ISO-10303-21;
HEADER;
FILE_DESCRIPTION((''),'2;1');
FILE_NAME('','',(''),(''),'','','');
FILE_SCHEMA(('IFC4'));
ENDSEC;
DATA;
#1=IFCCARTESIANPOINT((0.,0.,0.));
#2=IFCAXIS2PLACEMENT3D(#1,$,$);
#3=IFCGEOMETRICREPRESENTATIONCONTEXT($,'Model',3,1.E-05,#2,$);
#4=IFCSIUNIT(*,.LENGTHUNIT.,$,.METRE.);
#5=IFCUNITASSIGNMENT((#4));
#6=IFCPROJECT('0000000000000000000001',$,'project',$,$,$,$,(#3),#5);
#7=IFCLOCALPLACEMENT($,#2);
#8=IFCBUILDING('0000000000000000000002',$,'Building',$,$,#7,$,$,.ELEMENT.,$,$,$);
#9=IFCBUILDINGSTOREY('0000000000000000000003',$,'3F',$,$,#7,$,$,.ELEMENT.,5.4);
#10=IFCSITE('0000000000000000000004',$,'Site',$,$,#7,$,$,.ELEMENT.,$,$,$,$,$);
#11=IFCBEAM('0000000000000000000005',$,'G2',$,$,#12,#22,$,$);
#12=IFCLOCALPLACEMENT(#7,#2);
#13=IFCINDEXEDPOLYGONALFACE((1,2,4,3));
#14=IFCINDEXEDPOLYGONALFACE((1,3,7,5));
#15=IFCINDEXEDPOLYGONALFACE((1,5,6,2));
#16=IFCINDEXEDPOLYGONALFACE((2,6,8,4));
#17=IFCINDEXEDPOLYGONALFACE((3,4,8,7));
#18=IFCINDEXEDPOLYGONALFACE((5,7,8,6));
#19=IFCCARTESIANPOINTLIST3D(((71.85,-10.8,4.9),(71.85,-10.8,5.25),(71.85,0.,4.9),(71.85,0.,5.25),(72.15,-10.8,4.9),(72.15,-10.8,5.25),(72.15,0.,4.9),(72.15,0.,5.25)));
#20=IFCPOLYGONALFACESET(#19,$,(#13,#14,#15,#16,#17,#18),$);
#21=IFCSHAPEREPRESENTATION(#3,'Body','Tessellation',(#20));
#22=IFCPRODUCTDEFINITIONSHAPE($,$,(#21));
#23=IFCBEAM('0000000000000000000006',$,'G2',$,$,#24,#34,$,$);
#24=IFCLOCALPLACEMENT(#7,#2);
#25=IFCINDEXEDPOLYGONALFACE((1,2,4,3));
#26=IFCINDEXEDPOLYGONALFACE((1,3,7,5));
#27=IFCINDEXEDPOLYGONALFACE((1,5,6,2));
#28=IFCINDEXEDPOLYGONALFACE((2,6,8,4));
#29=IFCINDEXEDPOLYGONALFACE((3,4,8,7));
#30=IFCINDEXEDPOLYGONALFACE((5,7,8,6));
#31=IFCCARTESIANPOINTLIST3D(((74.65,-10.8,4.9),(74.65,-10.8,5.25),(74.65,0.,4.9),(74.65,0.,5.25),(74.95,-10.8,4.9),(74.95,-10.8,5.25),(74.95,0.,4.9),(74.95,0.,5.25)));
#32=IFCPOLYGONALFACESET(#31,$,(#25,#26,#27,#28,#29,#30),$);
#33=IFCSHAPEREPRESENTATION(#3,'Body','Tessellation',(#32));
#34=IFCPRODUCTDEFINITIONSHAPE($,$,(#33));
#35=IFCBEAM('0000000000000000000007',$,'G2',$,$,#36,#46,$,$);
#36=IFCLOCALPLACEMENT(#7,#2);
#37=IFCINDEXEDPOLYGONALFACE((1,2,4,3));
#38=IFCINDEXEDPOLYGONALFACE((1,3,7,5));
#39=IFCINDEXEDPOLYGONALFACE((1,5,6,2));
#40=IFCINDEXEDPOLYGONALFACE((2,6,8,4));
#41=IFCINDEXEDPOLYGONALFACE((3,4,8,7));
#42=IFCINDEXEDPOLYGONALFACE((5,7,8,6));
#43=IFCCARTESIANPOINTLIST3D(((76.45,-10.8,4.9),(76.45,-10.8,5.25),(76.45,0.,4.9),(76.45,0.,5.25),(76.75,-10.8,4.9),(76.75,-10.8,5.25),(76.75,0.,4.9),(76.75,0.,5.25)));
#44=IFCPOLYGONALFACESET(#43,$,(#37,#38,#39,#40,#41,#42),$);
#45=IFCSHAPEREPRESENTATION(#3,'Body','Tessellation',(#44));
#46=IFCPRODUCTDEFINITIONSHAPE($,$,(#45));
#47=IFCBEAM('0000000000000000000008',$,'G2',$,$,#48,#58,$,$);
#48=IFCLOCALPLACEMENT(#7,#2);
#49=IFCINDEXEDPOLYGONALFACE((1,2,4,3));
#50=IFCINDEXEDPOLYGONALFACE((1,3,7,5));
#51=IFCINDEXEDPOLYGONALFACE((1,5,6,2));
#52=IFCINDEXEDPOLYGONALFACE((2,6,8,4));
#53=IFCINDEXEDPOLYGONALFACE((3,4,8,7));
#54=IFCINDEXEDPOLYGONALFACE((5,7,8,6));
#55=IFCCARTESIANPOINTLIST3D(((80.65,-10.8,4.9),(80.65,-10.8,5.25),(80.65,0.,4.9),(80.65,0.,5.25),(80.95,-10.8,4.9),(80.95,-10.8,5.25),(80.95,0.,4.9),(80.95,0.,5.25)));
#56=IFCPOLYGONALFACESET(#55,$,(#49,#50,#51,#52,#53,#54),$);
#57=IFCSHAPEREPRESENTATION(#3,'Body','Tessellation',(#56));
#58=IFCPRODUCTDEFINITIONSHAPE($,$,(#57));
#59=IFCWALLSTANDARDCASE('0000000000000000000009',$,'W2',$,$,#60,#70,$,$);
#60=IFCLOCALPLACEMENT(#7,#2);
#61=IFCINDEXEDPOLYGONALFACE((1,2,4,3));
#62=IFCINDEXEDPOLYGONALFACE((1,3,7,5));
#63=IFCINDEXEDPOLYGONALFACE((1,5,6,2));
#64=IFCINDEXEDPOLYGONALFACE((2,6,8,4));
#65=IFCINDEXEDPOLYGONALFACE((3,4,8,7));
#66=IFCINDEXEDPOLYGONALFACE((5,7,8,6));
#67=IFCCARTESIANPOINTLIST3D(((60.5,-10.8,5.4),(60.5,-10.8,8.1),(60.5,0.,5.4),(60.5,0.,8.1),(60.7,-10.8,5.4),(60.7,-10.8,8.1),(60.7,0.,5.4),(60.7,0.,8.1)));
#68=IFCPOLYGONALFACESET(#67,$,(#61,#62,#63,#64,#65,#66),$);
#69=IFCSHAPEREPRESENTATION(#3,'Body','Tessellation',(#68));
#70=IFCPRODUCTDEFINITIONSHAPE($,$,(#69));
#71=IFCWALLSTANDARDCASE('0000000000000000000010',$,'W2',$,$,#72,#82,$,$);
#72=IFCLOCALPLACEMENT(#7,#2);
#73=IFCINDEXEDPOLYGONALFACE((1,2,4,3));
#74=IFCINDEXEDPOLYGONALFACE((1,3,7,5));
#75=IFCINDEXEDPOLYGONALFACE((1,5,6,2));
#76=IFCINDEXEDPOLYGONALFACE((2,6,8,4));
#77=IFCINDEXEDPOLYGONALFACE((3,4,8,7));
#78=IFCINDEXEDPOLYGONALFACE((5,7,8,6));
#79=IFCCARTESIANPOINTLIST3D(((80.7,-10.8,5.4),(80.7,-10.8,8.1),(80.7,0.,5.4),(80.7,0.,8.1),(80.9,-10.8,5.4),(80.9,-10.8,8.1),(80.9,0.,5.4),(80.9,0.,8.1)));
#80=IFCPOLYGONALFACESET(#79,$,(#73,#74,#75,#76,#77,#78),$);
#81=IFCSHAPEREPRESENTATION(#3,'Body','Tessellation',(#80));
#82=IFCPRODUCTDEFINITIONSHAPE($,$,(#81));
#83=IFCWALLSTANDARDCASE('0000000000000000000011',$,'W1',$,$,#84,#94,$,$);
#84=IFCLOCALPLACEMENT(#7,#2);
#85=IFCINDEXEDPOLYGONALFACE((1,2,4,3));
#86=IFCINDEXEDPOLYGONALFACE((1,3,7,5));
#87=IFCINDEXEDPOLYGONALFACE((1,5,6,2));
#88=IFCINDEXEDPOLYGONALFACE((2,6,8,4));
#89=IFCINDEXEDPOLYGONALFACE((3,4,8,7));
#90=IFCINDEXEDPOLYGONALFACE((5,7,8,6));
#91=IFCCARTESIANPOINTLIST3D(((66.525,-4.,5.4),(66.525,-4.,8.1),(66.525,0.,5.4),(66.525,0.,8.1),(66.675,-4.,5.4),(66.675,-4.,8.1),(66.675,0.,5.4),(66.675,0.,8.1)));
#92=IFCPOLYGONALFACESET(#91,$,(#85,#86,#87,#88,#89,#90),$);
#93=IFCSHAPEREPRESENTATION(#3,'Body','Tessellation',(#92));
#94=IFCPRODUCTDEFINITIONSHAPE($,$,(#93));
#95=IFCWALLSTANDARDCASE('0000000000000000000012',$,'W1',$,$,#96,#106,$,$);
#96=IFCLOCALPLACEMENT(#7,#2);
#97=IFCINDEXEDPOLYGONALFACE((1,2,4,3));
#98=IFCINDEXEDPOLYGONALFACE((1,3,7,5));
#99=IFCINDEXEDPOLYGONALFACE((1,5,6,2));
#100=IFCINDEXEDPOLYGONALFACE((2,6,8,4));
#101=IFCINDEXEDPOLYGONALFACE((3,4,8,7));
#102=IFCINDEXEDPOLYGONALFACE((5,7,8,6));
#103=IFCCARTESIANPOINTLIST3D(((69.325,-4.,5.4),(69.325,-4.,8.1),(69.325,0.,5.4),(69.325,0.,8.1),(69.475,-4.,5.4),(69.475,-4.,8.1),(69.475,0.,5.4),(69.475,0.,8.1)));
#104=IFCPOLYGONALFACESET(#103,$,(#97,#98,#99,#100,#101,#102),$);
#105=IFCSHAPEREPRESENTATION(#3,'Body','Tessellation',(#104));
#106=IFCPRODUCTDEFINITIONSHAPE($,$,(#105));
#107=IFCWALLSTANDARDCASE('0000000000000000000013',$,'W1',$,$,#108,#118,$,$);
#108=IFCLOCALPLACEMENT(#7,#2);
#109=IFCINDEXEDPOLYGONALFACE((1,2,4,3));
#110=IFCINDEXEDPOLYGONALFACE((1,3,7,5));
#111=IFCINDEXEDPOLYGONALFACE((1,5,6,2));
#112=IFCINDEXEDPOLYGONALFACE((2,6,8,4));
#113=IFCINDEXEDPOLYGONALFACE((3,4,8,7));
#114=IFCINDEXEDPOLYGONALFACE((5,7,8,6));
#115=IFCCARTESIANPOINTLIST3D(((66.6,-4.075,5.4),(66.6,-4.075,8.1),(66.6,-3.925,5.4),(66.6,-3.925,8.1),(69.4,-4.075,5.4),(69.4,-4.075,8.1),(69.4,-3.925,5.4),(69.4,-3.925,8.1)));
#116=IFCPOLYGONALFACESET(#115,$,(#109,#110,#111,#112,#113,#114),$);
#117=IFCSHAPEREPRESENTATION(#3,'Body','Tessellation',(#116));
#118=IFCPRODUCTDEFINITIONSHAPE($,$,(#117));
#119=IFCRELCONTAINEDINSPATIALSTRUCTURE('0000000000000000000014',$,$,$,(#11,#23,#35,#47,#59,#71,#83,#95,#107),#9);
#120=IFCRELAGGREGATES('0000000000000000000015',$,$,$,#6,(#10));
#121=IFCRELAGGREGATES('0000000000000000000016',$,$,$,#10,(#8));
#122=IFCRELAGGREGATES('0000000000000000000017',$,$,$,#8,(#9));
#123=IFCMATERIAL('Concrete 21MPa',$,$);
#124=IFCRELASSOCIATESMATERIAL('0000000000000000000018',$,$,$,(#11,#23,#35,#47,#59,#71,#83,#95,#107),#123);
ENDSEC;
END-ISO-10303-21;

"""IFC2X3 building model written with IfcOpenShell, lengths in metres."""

from ifc_helpers import new_model, si_unit, frame, origin, origin_2d, place, context, project, spatial, rectangle, extrude, material, element, save


model = new_model("IFC2X3")

# Units and contexts
model_context = context("Model", 3, precision=1e-05, world=origin())
ifc_project = project(units=[si_unit("LENGTHUNIT", "METRE")], contexts=[model_context])

# Site, building, storey
placement = place(None, origin())
site = spatial("IfcSite", under=ifc_project, at=placement, Name="Site", CompositionType="ELEMENT")
building = spatial("IfcBuilding", under=site, at=placement, Name="Building", CompositionType="ELEMENT")
storey = spatial("IfcBuildingStorey", under=building, at=placement, Name="3F", CompositionType="ELEMENT", Elevation=5.4)

# Shared definitions
ifc_material = material(Name="Concrete 21MPa")

# Beams
for number, where, name in (
    (1, (72.0, -5.4, 4.9), "G2"),
    (2, (74.8, -5.4, 4.9), "G2"),
    (3, (76.6, -5.4, 4.9), "G2"),
    (4, (80.8, -5.4, 4.9), "G2"),
):
    element("IfcBeam", number, at=place(None, frame(where)), inside=storey, material=ifc_material, Name=name, context=model_context, shape_type="SweptSolid", body=[
        extrude(rectangle(XDim=0.3, YDim=10.8, at=origin_2d()), origin(), (0.0, 0.0, 1.0), 0.35),
    ])

# Walls
for number, where, name in (
    (5, (60.6, -5.4, 5.4), "W2"),
    (6, (80.8, -5.4, 5.4), "W2"),
):
    element("IfcWallStandardCase", number, at=place(None, frame(where)), inside=storey, material=ifc_material, Name=name, context=model_context, shape_type="SweptSolid", body=[
        extrude(rectangle(XDim=0.2, YDim=10.8, at=origin_2d()), origin(), (0.0, 0.0, 1.0), 2.7),
    ])
for number, where, name in (
    (7, (66.6, -2.0, 5.4), "W1"),
    (8, (69.4, -2.0, 5.4), "W1"),
):
    element("IfcWallStandardCase", number, at=place(None, frame(where)), inside=storey, material=ifc_material, Name=name, context=model_context, shape_type="SweptSolid", body=[
        extrude(rectangle(XDim=0.15, YDim=4.0, at=origin_2d()), origin(), (0.0, 0.0, 1.0), 2.7),
    ])
wall_placement = place(None, frame((68.0, -4.0, 5.4)))
element("IfcWallStandardCase", 9, at=wall_placement, inside=storey, material=ifc_material, Name="W1", context=model_context, shape_type="SweptSolid", body=[
    extrude(rectangle(XDim=2.8, YDim=0.15, at=origin_2d()), origin(), (0.0, 0.0, 1.0), 2.7),
])

save(model, "model.ifc")
